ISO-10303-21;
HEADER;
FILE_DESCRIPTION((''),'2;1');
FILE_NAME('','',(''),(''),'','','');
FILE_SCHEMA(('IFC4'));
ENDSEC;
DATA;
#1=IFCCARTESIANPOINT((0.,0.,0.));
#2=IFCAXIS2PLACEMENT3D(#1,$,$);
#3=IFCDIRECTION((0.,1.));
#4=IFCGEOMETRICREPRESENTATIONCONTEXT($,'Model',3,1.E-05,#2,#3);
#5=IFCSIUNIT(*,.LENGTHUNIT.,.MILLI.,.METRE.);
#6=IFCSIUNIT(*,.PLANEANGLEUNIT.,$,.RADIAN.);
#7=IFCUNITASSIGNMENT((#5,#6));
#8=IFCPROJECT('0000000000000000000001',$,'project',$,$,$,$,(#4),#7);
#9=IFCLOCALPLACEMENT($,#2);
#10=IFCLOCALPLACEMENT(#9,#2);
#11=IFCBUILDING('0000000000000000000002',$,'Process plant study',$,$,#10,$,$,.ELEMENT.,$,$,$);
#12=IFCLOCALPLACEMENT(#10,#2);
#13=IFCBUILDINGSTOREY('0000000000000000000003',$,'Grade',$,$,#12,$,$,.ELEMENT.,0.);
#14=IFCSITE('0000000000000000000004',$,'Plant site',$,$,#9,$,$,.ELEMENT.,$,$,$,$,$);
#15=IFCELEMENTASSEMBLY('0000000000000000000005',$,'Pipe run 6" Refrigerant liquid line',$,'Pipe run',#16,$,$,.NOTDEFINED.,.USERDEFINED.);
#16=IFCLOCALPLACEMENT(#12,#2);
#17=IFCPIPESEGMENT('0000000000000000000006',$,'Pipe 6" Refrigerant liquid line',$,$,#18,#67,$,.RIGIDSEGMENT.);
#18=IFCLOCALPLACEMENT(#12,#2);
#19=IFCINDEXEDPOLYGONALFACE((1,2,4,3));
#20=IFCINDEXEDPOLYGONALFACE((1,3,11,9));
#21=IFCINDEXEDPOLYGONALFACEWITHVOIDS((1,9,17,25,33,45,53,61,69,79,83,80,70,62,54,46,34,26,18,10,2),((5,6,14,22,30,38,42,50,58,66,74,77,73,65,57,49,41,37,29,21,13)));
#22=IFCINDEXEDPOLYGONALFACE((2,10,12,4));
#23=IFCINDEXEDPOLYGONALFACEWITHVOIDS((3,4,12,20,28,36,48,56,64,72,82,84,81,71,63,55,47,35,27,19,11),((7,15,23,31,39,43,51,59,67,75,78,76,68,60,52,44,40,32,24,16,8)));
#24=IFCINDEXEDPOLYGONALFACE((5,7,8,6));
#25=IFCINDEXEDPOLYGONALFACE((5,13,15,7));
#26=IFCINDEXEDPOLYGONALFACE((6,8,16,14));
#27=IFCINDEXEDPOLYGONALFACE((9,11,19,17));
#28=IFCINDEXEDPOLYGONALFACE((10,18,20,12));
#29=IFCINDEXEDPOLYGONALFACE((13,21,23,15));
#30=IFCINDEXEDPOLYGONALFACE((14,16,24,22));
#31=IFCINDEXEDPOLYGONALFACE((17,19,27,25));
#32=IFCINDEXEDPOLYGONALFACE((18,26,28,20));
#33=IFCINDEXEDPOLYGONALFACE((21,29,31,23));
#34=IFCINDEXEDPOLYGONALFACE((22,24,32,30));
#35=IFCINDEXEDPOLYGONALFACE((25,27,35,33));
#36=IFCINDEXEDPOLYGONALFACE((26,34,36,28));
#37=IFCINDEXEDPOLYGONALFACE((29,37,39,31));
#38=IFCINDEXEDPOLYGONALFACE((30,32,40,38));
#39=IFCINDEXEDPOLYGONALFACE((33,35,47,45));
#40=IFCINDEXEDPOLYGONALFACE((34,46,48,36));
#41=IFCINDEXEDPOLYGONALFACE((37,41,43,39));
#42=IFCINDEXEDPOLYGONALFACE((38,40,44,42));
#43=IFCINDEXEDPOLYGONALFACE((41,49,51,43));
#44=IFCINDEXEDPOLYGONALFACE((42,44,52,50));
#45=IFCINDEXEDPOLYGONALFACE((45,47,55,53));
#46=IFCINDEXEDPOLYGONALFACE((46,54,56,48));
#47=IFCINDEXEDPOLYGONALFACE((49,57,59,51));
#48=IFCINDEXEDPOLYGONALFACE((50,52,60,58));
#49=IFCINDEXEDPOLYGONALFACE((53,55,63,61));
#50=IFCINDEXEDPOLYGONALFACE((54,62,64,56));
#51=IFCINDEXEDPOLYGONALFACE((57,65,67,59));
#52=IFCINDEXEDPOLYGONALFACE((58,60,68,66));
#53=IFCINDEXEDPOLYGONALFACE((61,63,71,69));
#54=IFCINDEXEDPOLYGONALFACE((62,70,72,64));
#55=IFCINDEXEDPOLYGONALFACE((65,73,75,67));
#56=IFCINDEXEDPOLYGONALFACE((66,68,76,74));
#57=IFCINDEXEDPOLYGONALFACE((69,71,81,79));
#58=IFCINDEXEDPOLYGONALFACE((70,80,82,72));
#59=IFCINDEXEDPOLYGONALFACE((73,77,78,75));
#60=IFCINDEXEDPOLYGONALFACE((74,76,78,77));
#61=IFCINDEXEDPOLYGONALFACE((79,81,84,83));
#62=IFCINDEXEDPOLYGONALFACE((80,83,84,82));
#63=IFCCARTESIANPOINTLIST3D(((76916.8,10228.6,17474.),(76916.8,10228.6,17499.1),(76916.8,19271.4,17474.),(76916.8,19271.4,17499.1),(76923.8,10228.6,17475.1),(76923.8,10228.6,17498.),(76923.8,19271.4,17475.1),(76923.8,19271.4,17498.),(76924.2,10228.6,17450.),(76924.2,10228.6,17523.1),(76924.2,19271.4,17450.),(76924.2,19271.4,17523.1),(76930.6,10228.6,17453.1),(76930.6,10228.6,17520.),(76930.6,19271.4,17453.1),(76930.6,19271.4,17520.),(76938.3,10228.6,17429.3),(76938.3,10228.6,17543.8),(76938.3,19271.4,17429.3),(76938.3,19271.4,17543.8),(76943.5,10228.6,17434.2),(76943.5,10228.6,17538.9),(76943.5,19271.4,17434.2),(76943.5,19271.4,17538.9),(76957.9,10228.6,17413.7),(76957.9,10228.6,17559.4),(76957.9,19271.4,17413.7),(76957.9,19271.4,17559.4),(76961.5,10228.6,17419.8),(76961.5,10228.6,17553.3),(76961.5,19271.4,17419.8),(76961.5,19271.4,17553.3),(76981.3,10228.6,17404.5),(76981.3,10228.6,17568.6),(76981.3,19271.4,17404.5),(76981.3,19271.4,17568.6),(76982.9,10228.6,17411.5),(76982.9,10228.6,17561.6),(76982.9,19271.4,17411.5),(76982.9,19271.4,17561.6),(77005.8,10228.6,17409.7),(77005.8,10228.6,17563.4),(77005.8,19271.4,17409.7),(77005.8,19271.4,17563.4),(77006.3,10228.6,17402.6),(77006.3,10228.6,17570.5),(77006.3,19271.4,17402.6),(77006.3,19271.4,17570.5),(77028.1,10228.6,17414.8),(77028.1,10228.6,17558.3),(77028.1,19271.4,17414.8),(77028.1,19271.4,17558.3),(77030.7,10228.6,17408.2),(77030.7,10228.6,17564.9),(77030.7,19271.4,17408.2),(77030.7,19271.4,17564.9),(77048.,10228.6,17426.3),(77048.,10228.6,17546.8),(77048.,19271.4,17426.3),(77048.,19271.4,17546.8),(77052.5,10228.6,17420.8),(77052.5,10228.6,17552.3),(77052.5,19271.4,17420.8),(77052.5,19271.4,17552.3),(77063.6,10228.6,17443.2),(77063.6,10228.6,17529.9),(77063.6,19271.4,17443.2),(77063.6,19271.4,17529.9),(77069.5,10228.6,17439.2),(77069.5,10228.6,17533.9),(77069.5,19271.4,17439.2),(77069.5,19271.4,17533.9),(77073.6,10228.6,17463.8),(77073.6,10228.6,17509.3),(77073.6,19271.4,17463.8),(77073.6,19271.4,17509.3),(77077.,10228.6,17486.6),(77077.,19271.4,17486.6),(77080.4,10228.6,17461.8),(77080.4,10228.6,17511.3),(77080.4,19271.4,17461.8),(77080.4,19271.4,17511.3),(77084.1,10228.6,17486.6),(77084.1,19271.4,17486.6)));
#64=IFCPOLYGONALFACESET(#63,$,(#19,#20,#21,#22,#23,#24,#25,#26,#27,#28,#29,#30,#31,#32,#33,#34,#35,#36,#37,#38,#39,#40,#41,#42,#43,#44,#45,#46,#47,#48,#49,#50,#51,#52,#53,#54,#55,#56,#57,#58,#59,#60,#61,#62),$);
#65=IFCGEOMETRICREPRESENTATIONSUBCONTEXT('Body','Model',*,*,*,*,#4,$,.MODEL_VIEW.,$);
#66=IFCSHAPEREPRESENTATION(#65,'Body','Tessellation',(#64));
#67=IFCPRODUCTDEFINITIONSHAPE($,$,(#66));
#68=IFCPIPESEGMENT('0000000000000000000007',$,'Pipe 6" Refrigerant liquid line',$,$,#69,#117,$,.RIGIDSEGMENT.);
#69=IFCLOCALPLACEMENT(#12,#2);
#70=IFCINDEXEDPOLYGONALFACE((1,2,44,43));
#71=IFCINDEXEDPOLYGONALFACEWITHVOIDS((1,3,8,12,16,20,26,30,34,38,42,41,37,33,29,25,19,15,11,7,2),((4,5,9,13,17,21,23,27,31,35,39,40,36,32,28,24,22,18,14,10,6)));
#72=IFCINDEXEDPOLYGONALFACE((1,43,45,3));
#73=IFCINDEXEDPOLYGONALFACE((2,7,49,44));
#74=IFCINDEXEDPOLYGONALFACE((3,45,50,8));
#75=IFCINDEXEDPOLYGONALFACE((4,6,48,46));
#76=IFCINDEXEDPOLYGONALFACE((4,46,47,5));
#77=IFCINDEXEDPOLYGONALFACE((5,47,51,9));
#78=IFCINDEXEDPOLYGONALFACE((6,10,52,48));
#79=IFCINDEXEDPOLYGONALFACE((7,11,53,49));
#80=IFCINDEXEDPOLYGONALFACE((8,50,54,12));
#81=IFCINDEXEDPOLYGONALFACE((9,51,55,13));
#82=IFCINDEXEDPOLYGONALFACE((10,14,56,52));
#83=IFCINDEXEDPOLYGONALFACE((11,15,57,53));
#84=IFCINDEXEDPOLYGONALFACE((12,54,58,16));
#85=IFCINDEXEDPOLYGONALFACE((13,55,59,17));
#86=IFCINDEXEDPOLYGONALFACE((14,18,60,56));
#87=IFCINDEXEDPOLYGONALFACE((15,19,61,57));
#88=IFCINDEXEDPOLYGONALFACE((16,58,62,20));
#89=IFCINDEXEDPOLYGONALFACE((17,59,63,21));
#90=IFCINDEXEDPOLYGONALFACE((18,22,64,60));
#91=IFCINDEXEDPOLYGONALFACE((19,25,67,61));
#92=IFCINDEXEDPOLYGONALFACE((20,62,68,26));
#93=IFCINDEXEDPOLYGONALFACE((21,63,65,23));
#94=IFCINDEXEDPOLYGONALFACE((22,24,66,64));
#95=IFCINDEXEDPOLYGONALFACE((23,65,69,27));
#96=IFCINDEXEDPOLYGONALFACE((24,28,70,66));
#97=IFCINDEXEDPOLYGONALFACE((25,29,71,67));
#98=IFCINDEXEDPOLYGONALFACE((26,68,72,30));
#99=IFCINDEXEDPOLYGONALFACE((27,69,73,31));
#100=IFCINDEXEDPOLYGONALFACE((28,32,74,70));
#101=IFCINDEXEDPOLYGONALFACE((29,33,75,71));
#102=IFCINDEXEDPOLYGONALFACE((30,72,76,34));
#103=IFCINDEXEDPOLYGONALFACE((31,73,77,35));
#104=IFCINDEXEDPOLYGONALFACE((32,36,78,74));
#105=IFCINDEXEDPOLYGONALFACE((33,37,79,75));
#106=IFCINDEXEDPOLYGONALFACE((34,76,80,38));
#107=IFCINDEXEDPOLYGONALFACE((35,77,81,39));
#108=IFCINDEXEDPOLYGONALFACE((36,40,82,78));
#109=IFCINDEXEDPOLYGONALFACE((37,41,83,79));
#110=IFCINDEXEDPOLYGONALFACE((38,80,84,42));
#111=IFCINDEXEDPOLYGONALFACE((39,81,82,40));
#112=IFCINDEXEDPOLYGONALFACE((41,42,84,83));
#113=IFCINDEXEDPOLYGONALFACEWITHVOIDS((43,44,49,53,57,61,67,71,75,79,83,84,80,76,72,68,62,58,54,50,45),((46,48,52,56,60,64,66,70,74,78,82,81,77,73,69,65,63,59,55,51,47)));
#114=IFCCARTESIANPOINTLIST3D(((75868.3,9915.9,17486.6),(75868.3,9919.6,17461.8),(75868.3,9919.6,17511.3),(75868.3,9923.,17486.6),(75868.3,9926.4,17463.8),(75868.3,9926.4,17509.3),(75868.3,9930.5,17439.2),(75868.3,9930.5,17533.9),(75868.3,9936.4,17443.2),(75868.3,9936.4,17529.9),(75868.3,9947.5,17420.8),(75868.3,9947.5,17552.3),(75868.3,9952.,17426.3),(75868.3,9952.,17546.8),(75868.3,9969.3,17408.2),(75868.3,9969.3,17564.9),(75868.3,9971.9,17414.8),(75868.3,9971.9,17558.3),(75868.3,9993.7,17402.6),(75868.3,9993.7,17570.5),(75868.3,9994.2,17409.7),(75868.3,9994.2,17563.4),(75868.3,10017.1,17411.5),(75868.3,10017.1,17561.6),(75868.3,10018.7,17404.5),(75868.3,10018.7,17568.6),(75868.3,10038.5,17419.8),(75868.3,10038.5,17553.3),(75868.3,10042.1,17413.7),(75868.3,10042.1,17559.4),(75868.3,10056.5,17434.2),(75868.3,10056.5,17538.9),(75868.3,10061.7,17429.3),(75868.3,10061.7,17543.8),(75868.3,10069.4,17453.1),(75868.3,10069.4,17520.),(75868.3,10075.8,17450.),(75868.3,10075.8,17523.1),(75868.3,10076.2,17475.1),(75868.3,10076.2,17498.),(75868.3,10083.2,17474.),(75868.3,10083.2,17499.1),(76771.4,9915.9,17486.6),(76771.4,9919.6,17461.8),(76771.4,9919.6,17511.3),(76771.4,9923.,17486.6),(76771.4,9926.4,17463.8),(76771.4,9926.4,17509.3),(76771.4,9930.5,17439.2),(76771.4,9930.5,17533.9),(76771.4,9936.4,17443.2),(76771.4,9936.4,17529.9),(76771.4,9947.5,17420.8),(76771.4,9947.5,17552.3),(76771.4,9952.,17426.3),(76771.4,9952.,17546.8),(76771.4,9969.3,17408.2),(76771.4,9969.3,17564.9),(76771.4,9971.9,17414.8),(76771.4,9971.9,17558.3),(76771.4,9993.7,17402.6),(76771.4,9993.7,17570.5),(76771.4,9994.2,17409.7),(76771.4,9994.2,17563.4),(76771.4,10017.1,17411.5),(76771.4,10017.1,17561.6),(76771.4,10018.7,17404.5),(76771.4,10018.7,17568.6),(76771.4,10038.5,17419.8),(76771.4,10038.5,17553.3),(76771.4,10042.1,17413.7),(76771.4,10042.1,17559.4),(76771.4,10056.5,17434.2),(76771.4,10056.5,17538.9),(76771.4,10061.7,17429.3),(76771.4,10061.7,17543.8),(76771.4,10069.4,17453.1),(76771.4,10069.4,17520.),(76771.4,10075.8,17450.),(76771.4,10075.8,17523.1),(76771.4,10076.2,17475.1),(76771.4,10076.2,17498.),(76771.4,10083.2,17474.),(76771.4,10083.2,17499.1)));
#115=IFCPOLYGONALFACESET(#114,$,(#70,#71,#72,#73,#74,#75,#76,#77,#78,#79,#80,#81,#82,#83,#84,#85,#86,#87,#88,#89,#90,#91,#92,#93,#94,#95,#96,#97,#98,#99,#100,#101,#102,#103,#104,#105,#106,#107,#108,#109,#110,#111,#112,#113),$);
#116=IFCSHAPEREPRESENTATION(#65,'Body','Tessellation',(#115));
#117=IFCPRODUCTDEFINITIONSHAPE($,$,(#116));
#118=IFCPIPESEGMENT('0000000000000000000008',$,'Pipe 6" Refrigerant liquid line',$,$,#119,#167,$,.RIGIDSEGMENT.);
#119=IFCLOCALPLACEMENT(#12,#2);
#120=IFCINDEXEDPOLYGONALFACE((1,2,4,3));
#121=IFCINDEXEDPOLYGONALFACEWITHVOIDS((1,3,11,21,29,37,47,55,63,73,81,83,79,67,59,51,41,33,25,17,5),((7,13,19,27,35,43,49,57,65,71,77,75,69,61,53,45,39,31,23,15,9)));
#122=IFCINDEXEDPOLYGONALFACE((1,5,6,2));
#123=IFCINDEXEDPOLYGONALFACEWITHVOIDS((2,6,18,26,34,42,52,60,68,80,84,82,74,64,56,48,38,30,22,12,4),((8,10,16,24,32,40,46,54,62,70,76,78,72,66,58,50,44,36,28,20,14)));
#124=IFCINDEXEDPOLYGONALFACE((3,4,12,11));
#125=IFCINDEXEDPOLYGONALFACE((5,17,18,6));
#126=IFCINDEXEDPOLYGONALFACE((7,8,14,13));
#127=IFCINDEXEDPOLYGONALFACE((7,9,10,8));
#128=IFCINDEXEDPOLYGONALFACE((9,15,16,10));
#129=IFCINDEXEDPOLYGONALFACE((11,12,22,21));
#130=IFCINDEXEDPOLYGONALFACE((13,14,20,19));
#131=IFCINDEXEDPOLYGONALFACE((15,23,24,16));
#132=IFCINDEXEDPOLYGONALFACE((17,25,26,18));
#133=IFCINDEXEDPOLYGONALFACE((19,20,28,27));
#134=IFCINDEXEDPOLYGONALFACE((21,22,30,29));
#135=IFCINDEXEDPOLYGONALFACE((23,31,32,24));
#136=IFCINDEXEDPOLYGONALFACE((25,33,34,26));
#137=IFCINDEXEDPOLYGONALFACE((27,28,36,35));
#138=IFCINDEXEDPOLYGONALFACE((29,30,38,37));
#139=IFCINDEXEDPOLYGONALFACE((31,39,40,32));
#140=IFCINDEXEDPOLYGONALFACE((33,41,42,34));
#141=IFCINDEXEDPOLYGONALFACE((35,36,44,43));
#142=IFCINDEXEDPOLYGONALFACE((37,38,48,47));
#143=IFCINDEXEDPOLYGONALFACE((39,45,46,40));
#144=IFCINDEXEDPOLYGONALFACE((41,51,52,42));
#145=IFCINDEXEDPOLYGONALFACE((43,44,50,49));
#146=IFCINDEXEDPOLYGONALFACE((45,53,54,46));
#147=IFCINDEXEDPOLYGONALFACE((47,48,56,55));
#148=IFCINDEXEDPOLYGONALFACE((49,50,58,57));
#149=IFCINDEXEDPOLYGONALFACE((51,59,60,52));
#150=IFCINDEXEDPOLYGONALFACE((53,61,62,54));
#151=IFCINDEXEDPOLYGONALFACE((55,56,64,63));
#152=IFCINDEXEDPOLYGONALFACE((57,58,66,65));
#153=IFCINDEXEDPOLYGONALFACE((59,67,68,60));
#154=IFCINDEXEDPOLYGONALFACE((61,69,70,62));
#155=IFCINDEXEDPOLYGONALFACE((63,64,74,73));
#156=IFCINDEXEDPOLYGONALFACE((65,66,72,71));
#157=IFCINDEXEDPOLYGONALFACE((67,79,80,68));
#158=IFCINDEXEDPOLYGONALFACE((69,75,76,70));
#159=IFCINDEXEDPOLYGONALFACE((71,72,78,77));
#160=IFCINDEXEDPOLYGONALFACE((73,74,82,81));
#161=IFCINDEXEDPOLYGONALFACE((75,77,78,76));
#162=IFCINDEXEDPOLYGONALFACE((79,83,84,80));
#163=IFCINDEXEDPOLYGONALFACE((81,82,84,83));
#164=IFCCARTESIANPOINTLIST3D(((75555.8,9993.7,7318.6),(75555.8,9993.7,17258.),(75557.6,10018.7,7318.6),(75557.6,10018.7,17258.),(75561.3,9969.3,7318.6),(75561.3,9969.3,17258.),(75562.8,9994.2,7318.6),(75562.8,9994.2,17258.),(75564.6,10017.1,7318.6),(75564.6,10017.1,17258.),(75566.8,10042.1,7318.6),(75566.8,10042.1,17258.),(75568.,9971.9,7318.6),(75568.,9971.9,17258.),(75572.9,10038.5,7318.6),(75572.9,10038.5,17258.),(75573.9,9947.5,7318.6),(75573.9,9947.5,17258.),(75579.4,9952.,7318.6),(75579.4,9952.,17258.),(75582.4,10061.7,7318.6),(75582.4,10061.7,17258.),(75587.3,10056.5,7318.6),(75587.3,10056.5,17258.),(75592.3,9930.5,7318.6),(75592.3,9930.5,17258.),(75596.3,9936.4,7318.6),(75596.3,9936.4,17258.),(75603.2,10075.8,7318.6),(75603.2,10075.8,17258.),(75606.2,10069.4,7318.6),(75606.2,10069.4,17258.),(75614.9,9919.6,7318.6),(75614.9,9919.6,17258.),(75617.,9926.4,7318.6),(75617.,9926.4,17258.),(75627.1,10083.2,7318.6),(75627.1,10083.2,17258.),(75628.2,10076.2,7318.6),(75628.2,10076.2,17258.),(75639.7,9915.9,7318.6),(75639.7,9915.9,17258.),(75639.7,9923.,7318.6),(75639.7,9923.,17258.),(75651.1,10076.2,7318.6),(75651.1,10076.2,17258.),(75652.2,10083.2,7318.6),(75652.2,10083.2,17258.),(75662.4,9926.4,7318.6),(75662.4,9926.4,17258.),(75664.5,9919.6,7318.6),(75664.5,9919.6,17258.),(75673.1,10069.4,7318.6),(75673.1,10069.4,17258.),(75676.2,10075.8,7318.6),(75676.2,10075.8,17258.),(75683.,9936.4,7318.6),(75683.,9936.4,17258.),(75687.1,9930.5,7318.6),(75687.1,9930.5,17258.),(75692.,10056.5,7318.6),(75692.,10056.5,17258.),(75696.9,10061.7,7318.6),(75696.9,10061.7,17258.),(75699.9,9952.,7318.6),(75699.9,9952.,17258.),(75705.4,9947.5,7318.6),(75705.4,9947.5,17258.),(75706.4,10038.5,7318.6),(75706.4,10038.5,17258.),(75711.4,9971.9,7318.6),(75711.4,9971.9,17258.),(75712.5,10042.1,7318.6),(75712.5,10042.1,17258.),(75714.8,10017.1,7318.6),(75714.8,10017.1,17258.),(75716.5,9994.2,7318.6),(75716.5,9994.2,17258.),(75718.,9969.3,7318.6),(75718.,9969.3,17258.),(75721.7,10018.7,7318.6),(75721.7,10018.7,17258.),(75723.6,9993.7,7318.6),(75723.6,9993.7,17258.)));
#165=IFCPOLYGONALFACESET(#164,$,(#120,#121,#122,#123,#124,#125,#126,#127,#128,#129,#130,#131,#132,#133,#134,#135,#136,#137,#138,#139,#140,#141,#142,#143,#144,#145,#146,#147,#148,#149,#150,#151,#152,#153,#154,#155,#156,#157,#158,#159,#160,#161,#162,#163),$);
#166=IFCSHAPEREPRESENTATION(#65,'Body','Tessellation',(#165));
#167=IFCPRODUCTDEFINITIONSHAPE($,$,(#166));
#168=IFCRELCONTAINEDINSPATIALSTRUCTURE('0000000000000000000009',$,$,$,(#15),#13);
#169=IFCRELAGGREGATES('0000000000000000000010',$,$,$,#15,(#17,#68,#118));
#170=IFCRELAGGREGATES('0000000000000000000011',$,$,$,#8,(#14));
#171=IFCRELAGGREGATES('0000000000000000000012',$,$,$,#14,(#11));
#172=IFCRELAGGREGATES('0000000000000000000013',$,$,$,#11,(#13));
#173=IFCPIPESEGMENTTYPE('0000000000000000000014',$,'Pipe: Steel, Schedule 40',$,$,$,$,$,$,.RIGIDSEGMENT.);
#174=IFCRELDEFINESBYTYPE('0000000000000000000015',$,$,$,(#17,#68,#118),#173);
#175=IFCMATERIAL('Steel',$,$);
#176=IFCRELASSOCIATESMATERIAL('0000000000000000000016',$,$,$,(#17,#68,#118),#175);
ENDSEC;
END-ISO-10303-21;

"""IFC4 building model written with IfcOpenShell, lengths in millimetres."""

from ifc_helpers import new_model, si_unit, direction, frame, origin, origin_with_axes, origin_2d, place, context, subcontext, project, spatial, hollow_circle, extrude, material, type_object, element, aggregate, save


model = new_model("IFC4")

# Units and contexts
model_context = context("Model", 3, precision=1e-05, world=origin(), true_north=direction((0.0, 1.0)))
body_context = subcontext(model_context, "Body", "Model", "MODEL_VIEW")
ifc_project = project(units=[si_unit("LENGTHUNIT", "METRE", prefix="MILLI"), si_unit("PLANEANGLEUNIT", "RADIAN")], contexts=[model_context])

# Site, building, storey
site_placement = place(None, origin())
site = spatial("IfcSite", under=ifc_project, at=site_placement, Name="Plant site", CompositionType="ELEMENT")
building_placement = place(site_placement, origin())
building = spatial("IfcBuilding", under=site, at=building_placement, Name="Process plant study", CompositionType="ELEMENT")
storey_placement = place(building_placement, origin())
storey = spatial("IfcBuildingStorey", under=building, at=storey_placement, Name="Grade", CompositionType="ELEMENT", Elevation=0.0)

# Element assembly, pipe segments
ifc_material = material(Name="Steel")
pipe_segment_type = type_object("IfcPipeSegmentType", Name="Pipe: Steel, Schedule 40", PredefinedType="RIGIDSEGMENT")
assembly_1_placement = place(storey_placement, origin_with_axes())
assembly_1 = element("IfcElementAssembly", 1, at=assembly_1_placement, inside=storey, Name="Pipe run 6\" Refrigerant liquid line", ObjectType="Pipe run", AssemblyPlace="NOTDEFINED", PredefinedType="USERDEFINED")
pipe_segment_1_placement = place(storey_placement, origin_with_axes())
pipe_segment_1 = element("IfcPipeSegment", 2, at=pipe_segment_1_placement, type_object=pipe_segment_type, material=ifc_material, Name="Pipe 6\" Refrigerant liquid line", PredefinedType="RIGIDSEGMENT", context=body_context, shape_type="SweptSolid", body=[
    extrude(hollow_circle(Radius=84.1, WallThickness=7.1, at=origin_2d()), frame((77000.0, 19271.4, 17486.5), z_axis=(0.0, -1.0, 0.0), x_axis=(1.0, 0.0, 0.0)), (0.0, 0.0, 1.0), 9042.8),
])
pipe_segment_2_placement = place(storey_placement, origin_with_axes())
pipe_segment_2 = element("IfcPipeSegment", 3, at=pipe_segment_2_placement, type_object=pipe_segment_type, material=ifc_material, Name="Pipe 6\" Refrigerant liquid line", PredefinedType="RIGIDSEGMENT", context=body_context, shape_type="SweptSolid", body=[
    extrude(hollow_circle(Radius=84.1, WallThickness=7.1, at=origin_2d()), frame((76771.4, 10000.0, 17486.5), z_axis=(-1.0, 0.0, 0.0), x_axis=(0.0, -1.0, 0.0)), (0.0, 0.0, 1.0), 903.1),
])
pipe_segment_3_placement = place(storey_placement, origin_with_axes())
pipe_segment_3 = element("IfcPipeSegment", 4, at=pipe_segment_3_placement, type_object=pipe_segment_type, material=ifc_material, Name="Pipe 6\" Refrigerant liquid line", PredefinedType="RIGIDSEGMENT", context=body_context, shape_type="SweptSolid", body=[
    extrude(hollow_circle(Radius=84.1, WallThickness=7.1, at=origin_2d()), frame((75639.7, 10000.0, 17258.0), z_axis=(0.0, 0.0, -1.0), x_axis=(0.0, -1.0, 0.0)), (0.0, 0.0, 1.0), 9939.4),
])

aggregate(assembly_1, [pipe_segment_1, pipe_segment_2, pipe_segment_3])

save(model, "model.ifc")
